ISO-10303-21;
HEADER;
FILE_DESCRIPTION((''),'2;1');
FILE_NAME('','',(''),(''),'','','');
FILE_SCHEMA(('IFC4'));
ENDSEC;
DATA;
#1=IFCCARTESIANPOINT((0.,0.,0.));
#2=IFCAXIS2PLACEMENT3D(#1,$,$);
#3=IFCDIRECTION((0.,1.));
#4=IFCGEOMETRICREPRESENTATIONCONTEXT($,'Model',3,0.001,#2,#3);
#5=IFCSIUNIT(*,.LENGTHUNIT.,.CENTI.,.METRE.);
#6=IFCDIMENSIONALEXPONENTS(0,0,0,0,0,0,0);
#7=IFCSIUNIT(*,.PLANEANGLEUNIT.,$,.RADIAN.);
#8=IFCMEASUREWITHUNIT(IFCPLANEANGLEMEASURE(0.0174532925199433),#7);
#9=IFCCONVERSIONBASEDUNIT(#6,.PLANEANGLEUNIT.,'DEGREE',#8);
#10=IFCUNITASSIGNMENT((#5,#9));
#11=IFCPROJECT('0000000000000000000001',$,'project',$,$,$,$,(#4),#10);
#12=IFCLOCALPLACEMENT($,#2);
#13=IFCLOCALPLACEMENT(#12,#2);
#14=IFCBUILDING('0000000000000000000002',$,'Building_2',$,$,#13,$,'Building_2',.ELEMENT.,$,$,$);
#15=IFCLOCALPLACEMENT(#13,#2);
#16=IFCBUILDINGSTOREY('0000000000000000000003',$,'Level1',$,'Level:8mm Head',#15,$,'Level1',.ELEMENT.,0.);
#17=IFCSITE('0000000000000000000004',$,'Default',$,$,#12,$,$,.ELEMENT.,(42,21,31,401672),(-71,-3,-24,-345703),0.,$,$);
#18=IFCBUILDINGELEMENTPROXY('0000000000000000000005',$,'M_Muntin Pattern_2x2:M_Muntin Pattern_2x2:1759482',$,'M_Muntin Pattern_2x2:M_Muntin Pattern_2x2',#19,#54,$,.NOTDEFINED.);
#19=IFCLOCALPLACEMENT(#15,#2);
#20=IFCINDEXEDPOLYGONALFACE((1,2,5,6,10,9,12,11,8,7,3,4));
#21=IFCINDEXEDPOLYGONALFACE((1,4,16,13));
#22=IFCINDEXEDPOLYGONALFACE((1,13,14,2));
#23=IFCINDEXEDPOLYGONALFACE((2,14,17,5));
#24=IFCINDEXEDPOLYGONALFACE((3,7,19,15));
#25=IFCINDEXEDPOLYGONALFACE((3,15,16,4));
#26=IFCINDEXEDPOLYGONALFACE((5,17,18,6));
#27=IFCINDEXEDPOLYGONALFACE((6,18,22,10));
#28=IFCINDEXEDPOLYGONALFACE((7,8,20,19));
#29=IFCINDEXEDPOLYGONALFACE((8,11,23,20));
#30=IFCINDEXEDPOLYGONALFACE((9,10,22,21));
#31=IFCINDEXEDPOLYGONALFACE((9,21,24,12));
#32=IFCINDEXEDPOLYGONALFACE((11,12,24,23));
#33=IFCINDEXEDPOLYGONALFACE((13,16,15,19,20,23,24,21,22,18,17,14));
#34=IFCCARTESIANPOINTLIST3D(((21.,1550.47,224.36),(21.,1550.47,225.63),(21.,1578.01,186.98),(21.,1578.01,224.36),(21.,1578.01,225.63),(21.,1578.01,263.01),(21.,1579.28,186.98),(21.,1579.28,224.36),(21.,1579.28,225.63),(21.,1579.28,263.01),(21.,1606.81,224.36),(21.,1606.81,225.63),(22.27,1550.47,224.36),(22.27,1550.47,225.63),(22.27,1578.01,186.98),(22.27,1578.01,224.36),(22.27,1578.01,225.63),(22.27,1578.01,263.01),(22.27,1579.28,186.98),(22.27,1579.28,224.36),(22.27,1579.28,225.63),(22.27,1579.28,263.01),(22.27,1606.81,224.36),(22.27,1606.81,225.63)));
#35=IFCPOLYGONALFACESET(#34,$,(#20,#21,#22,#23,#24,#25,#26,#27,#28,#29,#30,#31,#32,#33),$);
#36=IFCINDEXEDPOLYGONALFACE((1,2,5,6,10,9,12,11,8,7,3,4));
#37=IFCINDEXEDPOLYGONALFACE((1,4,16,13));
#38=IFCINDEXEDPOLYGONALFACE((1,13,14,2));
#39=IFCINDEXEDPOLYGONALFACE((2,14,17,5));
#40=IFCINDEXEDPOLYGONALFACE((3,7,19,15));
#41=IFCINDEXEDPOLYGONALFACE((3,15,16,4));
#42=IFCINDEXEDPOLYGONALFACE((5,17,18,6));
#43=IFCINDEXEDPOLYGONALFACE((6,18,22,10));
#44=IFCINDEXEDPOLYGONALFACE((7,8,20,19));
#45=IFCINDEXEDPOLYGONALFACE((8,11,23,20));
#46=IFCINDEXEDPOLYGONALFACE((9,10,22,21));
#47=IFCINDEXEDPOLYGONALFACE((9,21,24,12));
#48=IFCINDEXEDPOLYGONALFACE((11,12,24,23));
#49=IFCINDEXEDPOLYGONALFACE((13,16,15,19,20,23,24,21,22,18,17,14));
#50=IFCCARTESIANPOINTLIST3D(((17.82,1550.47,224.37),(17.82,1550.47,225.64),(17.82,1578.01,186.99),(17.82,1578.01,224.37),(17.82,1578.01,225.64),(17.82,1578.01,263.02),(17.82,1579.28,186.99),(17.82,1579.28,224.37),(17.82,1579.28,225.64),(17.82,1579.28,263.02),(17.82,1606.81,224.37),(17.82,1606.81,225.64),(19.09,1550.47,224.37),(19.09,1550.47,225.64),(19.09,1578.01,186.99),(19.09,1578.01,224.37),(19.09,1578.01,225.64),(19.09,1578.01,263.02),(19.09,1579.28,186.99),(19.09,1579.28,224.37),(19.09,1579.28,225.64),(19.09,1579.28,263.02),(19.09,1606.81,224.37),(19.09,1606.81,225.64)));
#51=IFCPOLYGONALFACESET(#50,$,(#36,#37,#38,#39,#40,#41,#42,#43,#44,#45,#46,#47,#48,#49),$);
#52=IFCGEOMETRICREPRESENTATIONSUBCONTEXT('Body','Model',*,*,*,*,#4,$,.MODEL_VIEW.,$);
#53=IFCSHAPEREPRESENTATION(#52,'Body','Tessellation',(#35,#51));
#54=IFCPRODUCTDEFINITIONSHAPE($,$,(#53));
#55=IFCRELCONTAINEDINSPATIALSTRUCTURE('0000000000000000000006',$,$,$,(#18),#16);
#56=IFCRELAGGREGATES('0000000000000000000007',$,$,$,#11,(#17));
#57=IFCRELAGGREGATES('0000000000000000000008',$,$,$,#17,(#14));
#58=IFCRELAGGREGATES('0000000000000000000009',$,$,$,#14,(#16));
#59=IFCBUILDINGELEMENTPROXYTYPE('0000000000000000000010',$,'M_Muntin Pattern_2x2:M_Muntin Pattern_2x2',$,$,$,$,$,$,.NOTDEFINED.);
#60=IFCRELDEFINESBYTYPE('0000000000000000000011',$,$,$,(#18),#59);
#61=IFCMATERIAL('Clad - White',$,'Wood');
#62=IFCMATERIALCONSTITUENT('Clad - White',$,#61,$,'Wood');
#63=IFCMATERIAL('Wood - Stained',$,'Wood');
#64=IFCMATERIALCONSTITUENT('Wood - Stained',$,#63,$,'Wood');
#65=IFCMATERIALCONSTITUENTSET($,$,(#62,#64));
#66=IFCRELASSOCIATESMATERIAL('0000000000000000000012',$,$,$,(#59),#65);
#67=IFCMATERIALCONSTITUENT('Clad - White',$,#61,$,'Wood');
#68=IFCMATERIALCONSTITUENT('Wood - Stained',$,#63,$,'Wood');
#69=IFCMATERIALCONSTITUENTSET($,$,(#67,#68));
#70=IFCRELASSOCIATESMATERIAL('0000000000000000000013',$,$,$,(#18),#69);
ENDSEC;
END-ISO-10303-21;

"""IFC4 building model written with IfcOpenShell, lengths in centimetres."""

from ifc_helpers import new_model, entity, si_unit, converted_unit, direction, frame, origin, place, context, subcontext, project, spatial, indexed_curve, outline, extrude, source, transform, mapped, material, constituent, constituent_set, type_object, type_shapes, element, save


model = new_model("IFC4")

# Units and contexts
model_context = context("Model", 3, precision=0.001, world=origin(), true_north=direction((0.0, 1.0)))
body_context = subcontext(model_context, "Body", "Model", "MODEL_VIEW")
ifc_project = project(units=[si_unit("LENGTHUNIT", "METRE", prefix="CENTI"), converted_unit("PLANEANGLEUNIT", "DEGREE", entity("IfcPlaneAngleMeasure", 0.0174532925199433), si_unit("PLANEANGLEUNIT", "RADIAN"), dimensions=[0, 0, 0, 0, 0, 0, 0])], contexts=[model_context])

# Site, building, storey
site_placement = place(None, origin())
site = spatial("IfcSite", under=ifc_project, at=site_placement, Name="Default", CompositionType="ELEMENT", RefLatitude=(42, 21, 31, 401672), RefLongitude=(-71, -3, -24, -345703), RefElevation=0.0)
building_placement = place(site_placement, origin())
building = spatial("IfcBuilding", under=site, at=building_placement, Name="Building_2", LongName="Building_2", CompositionType="ELEMENT")
storey_placement = place(building_placement, origin())
storey = spatial("IfcBuildingStorey", under=building, at=storey_placement, Name="Level1", ObjectType="Level:8mm Head", LongName="Level1", CompositionType="ELEMENT", Elevation=0.0)

# Shared definitions
ifc_material_1 = material(Name="Clad - White", Category="Wood")
ifc_material_2 = material(Name="Wood - Stained", Category="Wood")

# Building element proxy
ifc_constituent_1 = constituent(ifc_material_1, Name="Clad - White", Category="Wood")
ifc_constituent_2 = constituent(ifc_material_2, Name="Wood - Stained", Category="Wood")
ifc_constituent_set_1 = constituent_set(constituents=[ifc_constituent_1, ifc_constituent_2])
ifc_constituent_3 = constituent(ifc_material_1, Name="Clad - White", Category="Wood")
ifc_constituent_4 = constituent(ifc_material_2, Name="Wood - Stained", Category="Wood")
ifc_constituent_set_2 = constituent_set(constituents=[ifc_constituent_3, ifc_constituent_4])
building_element_proxy_type_1 = type_object("IfcBuildingElementProxyType", Name="M_Muntin Pattern_2x2:M_Muntin Pattern_2x2", PredefinedType="NOTDEFINED", material=ifc_constituent_set_2)
shared_shape_1 = source(origin(), body_context, "Body", "SweptSolid", [
    extrude(outline(indexed_curve([(0.64, -0.64), (38.01, -0.64), (38.01, 0.63), (0.64, 0.63), (0.64, 28.17), (-0.63, 28.17), (-0.63, 0.63), (-38.02, 0.63), (-38.02, -0.64), (-0.63, -0.64), (-0.63, -28.17), (0.64, -28.17), (0.64, -0.64)], self_intersect=False)), frame((0.0, 0.95, 38.01), z_axis=(0.0, 1.0, 0.0), x_axis=(0.0, 0.0, 1.0)), (0.0, 0.0, 1.0), 1.27),
    extrude(outline(indexed_curve([(0.64, -0.64), (38.02, -0.64), (38.02, 0.63), (0.64, 0.63), (0.64, 28.17), (-0.63, 28.17), (-0.63, 0.63), (-38.02, 0.63), (-38.02, -0.64), (-0.63, -0.64), (-0.63, -28.17), (0.64, -28.17), (0.64, -0.64)], self_intersect=False)), frame((0.0, -2.22, 38.02), z_axis=(0.0, 1.0, 0.0), x_axis=(0.0, 0.0, 1.0)), (0.0, 0.0, 1.0), 1.27),
])
type_shapes(building_element_proxy_type_1, [shared_shape_1])
proxy_1_placement = place(storey_placement, frame((20.05, 1578.64, 186.99), z_axis=(0.0, 0.0, 1.0), x_axis=(0.0, -1.0, 0.0)))
element("IfcBuildingElementProxy", 1, at=proxy_1_placement, inside=storey, type_object=building_element_proxy_type_1, material=ifc_constituent_set_1, Name="M_Muntin Pattern_2x2:M_Muntin Pattern_2x2:1759482", ObjectType="M_Muntin Pattern_2x2:M_Muntin Pattern_2x2", PredefinedType="NOTDEFINED", context=body_context, shape_type="MappedRepresentation", body=[
    mapped(shared_shape_1, transform((0.0, 0.0, 0.0), scale=1.0)),
])

save(model, "model.ifc")
